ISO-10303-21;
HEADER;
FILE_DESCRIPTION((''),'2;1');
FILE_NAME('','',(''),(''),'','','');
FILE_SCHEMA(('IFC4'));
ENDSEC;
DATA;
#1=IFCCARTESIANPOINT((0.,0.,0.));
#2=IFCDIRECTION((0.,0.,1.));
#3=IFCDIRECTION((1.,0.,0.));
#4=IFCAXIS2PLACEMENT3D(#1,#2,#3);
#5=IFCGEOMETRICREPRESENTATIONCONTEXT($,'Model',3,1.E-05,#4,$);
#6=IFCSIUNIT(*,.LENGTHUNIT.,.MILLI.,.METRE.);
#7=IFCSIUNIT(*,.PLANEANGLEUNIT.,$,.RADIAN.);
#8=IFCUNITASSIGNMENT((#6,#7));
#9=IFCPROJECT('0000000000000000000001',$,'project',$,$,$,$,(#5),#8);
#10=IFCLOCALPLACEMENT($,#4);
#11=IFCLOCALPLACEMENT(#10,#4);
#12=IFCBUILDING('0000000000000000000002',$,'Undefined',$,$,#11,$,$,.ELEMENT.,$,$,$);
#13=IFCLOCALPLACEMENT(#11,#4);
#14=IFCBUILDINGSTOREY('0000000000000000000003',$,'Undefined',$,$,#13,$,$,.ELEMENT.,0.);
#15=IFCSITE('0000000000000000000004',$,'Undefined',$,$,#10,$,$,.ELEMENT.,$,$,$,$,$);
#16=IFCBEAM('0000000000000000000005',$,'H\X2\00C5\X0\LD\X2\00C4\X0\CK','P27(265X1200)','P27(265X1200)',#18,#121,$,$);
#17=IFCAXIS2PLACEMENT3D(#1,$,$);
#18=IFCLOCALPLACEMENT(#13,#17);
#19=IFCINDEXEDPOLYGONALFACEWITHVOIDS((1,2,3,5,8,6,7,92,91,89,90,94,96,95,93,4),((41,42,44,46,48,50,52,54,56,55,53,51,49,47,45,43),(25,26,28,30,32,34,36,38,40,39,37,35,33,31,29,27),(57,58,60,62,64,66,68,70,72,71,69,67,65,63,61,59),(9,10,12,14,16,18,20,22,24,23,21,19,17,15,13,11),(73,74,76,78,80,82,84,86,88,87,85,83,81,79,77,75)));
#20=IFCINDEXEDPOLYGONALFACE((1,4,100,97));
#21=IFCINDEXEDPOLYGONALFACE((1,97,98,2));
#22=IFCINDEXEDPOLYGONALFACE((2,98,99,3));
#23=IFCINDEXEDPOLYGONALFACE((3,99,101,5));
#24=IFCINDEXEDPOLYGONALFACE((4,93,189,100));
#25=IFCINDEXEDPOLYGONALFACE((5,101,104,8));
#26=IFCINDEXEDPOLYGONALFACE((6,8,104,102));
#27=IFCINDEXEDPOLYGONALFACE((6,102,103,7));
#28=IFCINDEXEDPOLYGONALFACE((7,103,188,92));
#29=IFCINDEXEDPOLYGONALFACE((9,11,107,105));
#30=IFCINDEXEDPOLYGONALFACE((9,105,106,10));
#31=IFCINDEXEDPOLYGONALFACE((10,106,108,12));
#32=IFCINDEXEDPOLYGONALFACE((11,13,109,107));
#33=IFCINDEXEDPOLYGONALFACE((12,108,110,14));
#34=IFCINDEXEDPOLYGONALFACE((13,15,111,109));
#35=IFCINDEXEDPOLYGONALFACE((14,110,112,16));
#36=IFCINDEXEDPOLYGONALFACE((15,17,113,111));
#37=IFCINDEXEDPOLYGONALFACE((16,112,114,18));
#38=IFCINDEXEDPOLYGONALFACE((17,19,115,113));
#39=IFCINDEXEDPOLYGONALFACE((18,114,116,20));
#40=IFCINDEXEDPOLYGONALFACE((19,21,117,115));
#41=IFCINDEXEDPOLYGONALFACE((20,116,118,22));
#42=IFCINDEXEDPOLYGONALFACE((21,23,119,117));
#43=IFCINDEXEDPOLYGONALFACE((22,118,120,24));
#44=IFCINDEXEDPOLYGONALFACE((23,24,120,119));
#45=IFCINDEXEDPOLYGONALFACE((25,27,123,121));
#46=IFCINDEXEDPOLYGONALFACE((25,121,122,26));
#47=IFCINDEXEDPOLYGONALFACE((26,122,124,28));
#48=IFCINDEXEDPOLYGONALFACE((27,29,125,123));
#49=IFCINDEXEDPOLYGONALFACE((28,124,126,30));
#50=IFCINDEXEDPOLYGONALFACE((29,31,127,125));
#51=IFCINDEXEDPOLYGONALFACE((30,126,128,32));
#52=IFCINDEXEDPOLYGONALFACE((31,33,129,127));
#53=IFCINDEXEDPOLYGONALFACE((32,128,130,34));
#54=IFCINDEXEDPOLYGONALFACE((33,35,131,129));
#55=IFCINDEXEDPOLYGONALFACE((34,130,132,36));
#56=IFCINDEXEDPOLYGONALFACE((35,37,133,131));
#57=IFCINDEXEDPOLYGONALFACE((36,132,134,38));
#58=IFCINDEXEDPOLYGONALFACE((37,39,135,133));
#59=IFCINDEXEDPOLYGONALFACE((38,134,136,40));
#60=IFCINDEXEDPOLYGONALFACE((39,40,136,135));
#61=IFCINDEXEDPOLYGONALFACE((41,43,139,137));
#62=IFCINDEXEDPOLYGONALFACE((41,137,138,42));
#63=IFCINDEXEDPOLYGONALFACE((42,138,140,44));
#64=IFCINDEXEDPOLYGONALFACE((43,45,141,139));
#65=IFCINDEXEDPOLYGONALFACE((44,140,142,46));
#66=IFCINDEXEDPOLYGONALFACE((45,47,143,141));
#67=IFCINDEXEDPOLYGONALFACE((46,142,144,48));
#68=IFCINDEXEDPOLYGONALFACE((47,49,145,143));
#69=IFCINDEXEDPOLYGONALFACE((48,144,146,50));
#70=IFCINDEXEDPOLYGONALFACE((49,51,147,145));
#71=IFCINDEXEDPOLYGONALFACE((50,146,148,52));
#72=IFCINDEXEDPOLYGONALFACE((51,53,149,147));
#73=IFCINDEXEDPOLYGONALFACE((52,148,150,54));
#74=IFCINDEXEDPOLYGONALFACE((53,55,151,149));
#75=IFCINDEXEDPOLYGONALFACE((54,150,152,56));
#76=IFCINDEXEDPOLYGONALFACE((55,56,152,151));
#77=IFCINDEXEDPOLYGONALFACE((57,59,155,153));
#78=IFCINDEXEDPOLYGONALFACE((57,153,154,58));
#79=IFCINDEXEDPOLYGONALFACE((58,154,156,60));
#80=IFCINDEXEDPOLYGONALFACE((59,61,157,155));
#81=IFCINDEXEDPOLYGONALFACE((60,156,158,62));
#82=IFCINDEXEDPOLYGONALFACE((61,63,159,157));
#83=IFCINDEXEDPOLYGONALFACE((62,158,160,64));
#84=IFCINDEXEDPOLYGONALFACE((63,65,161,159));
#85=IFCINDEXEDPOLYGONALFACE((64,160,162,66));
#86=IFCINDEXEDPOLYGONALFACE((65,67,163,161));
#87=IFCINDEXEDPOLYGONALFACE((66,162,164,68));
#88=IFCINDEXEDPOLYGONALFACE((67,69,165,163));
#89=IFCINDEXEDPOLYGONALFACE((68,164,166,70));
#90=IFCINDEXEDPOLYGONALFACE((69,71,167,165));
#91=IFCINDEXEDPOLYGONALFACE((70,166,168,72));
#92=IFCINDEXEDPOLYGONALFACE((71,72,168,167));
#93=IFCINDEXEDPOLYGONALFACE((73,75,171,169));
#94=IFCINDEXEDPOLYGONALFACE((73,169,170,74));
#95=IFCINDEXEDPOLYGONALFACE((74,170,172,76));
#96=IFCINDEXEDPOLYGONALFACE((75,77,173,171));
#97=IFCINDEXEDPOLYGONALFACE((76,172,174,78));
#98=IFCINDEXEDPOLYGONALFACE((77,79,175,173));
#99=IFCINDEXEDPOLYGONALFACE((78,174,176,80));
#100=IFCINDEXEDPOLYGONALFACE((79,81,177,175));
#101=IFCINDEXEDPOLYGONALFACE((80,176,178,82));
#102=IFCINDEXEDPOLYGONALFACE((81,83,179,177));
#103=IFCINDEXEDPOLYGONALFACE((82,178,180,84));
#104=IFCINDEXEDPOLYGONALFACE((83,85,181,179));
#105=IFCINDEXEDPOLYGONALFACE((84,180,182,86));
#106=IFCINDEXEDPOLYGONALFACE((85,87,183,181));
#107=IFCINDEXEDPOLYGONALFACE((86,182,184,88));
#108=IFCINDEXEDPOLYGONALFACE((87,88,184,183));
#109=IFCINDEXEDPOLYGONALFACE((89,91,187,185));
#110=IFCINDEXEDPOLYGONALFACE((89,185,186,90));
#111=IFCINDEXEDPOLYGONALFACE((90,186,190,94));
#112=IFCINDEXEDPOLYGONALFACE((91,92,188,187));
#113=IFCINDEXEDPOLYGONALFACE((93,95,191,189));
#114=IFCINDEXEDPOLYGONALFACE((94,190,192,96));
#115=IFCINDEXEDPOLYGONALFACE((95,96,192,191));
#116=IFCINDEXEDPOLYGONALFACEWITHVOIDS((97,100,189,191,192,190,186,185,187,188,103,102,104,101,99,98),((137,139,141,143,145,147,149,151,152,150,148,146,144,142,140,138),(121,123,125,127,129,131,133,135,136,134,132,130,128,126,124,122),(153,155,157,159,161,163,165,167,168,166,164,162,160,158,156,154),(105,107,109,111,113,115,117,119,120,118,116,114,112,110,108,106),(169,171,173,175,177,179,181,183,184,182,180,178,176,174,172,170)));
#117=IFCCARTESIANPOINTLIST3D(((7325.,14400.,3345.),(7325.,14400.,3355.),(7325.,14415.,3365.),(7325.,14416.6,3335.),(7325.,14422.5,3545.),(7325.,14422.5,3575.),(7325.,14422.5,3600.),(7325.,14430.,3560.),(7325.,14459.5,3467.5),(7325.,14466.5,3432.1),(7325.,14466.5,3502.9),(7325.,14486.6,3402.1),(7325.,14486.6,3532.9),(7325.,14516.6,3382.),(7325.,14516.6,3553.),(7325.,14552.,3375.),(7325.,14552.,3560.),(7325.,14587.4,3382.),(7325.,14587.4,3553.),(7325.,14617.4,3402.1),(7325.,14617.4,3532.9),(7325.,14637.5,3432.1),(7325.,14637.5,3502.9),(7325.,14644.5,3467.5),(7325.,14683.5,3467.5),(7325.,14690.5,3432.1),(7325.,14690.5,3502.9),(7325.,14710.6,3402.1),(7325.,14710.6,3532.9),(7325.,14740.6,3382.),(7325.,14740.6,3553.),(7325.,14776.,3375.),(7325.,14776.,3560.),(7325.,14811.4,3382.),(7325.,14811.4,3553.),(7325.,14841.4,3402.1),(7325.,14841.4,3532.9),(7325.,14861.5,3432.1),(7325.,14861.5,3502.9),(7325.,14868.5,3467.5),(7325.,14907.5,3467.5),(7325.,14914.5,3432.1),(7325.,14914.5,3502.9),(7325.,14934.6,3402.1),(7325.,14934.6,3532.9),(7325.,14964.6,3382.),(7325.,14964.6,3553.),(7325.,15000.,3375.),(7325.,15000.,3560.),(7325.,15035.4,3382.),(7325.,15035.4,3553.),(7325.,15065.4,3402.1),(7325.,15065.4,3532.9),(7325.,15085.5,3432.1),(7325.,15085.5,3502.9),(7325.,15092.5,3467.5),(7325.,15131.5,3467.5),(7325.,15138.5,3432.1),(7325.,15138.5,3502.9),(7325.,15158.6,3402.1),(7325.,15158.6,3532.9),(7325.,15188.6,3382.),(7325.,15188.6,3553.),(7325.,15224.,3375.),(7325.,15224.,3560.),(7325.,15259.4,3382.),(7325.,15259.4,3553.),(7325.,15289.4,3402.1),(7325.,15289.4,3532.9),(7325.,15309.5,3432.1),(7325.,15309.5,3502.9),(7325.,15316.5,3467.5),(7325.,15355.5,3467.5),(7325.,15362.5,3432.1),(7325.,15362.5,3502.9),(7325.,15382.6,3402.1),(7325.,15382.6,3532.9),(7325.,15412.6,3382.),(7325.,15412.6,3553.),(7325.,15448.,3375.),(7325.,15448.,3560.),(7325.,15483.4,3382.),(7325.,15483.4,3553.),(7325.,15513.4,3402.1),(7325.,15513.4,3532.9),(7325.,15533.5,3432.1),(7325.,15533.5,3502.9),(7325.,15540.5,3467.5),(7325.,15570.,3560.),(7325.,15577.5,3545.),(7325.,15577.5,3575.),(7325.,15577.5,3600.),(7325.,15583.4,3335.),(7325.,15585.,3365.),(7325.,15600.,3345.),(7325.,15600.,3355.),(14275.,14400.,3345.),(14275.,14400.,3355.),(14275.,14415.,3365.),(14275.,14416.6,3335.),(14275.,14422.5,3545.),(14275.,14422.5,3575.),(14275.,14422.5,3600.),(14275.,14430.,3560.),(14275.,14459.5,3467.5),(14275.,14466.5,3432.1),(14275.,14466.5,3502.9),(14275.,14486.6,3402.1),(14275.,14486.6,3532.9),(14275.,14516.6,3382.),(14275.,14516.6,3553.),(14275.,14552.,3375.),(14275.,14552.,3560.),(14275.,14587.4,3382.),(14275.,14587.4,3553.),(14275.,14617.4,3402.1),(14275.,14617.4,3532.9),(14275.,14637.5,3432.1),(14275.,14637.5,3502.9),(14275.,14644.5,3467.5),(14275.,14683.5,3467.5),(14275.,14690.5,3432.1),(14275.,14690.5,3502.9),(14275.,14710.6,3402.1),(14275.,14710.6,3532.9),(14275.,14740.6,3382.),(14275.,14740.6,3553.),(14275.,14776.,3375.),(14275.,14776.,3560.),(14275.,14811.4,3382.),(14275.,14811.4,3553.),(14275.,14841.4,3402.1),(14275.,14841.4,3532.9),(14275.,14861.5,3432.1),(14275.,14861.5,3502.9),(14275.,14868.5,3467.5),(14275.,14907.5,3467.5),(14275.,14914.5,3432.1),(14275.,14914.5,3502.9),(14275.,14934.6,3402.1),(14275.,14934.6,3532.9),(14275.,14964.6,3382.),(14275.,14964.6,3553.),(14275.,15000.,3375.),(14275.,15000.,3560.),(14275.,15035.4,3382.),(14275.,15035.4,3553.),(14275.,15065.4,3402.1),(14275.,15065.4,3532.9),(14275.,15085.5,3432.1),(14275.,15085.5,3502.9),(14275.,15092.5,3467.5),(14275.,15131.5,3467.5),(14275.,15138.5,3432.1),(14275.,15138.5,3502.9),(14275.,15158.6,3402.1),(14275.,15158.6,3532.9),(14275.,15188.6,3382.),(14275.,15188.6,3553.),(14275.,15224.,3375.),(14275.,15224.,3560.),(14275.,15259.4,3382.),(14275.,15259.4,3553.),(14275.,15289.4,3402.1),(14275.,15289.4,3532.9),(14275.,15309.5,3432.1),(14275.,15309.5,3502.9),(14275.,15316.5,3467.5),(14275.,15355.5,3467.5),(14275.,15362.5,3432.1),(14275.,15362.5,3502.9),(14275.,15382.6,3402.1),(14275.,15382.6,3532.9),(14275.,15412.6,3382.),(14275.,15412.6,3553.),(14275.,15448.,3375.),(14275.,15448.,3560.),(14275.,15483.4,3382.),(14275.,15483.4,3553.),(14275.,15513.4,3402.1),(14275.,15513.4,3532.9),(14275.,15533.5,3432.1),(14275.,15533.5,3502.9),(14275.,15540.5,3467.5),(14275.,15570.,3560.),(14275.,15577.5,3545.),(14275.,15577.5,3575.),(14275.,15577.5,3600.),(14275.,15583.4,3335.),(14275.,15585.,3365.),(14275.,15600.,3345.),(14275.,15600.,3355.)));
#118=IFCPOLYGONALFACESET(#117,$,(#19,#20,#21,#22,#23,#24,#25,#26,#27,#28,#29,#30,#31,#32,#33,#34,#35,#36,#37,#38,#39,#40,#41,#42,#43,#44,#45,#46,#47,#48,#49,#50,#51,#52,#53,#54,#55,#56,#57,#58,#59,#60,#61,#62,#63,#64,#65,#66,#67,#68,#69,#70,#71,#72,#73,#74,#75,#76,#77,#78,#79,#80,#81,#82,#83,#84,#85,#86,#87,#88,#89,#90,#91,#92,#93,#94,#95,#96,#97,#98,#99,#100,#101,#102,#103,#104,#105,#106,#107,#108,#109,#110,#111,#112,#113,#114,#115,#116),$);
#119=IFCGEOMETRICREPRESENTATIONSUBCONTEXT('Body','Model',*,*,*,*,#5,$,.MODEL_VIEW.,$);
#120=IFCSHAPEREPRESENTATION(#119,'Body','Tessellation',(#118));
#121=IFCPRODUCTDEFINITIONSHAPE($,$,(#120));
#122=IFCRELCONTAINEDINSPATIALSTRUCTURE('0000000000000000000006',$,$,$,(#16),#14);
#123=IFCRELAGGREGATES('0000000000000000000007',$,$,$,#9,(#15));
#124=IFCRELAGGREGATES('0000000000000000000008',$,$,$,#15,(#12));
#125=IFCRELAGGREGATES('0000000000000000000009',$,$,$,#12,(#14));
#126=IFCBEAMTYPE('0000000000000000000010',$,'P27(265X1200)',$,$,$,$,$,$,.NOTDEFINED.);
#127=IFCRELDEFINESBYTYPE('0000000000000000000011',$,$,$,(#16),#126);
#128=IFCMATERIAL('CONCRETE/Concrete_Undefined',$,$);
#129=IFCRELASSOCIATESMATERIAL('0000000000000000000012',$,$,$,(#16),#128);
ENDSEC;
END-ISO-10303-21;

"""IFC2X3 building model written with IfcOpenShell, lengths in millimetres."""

from ifc_helpers import new_model, si_unit, frame, origin_with_axes, place, context, subcontext, project, spatial, polyline, outline, extrude, material, type_object, element, save


model = new_model("IFC2X3")

# Units and contexts
model_context = context("Model", 3, precision=1e-05, world=origin_with_axes())
body_context = subcontext(model_context, "Body", "Model", "MODEL_VIEW")
ifc_project = project(units=[si_unit("LENGTHUNIT", "METRE", prefix="MILLI"), si_unit("PLANEANGLEUNIT", "RADIAN")], contexts=[model_context])

# Site, building, storey
site_placement = place(None, origin_with_axes())
site = spatial("IfcSite", under=ifc_project, at=site_placement, Name="Undefined", CompositionType="ELEMENT")
building_placement = place(site_placement, origin_with_axes())
building = spatial("IfcBuilding", under=site, at=building_placement, Name="Undefined", CompositionType="ELEMENT")
storey_placement = place(building_placement, origin_with_axes())
storey = spatial("IfcBuildingStorey", under=building, at=storey_placement, Name="Undefined", CompositionType="ELEMENT", Elevation=0.0)

# Beam
ifc_material_1 = material(Name="CONCRETE/Concrete_Undefined")
beam_type_1 = type_object("IfcBeamType", Name="P27(265X1200)", PredefinedType="NOTDEFINED")
beam_1_placement = place(storey_placement, frame((7325.0, 15000.0, 3467.5), z_axis=(0.0, 0.0, 1.0), x_axis=(1.0, 0.0, 0.0)))
element("IfcBeam", 1, at=beam_1_placement, inside=storey, type_object=beam_type_1, material=ifc_material_1, Name="HÅLDÄCK", Description="P27(265X1200)", ObjectType="P27(265X1200)", context=body_context, shape_type="SweptSolid", body=[
    extrude(outline(polyline([(-583.4, -132.5), (-600.0, -122.5), (-600.0, -112.5), (-585.0, -102.5), (-577.5, 77.5), (-570.0, 92.5), (-577.5, 107.5), (-577.5, 132.5), (577.5, 132.5), (577.5, 107.5), (570.0, 92.5), (577.5, 77.5), (585.0, -102.5), (600.0, -112.5), (600.0, -122.5), (583.4, -132.5), (-583.4, -132.5)]), holes=[polyline([(-513.4, 65.4), (-533.5, 35.4), (-540.5, 0.0), (-533.5, -35.4), (-513.4, -65.4), (-483.4, -85.5), (-448.0, -92.5), (-412.6, -85.5), (-382.6, -65.4), (-362.5, -35.4), (-355.5, 0.0), (-362.5, 35.4), (-382.6, 65.4), (-412.6, 85.5), (-448.0, 92.5), (-483.4, 85.5), (-513.4, 65.4)]), polyline([(-289.4, 65.4), (-309.5, 35.4), (-316.5, 0.0), (-309.5, -35.4), (-289.4, -65.4), (-259.4, -85.5), (-224.0, -92.5), (-188.6, -85.5), (-158.6, -65.4), (-138.5, -35.4), (-131.5, 0.0), (-138.5, 35.4), (-158.6, 65.4), (-188.6, 85.5), (-224.0, 92.5), (-259.4, 85.5), (-289.4, 65.4)]), polyline([(-65.4, 65.4), (-85.5, 35.4), (-92.5, 0.0), (-85.5, -35.4), (-65.4, -65.4), (-35.4, -85.5), (0.0, -92.5), (35.4, -85.5), (65.4, -65.4), (85.5, -35.4), (92.5, 0.0), (85.5, 35.4), (65.4, 65.4), (35.4, 85.5), (0.0, 92.5), (-35.4, 85.5), (-65.4, 65.4)]), polyline([(158.6, 65.4), (138.5, 35.4), (131.5, 0.0), (138.5, -35.4), (158.6, -65.4), (188.6, -85.5), (224.0, -92.5), (259.4, -85.5), (289.4, -65.4), (309.5, -35.4), (316.5, 0.0), (309.5, 35.4), (289.4, 65.4), (259.4, 85.5), (224.0, 92.5), (188.6, 85.5), (158.6, 65.4)]), polyline([(382.6, 65.4), (362.5, 35.4), (355.5, 0.0), (362.5, -35.4), (382.6, -65.4), (412.6, -85.5), (448.0, -92.5), (483.4, -85.5), (513.4, -65.4), (533.5, -35.4), (540.5, 0.0), (533.5, 35.4), (513.4, 65.4), (483.4, 85.5), (448.0, 92.5), (412.6, 85.5), (382.6, 65.4)])]), frame((6950.0, 0.0, 0.0), z_axis=(-1.0, 0.0, 0.0), x_axis=(0.0, -1.0, 0.0)), (0.0, 0.0, 1.0), 6950.0),
])

save(model, "model.ifc")
